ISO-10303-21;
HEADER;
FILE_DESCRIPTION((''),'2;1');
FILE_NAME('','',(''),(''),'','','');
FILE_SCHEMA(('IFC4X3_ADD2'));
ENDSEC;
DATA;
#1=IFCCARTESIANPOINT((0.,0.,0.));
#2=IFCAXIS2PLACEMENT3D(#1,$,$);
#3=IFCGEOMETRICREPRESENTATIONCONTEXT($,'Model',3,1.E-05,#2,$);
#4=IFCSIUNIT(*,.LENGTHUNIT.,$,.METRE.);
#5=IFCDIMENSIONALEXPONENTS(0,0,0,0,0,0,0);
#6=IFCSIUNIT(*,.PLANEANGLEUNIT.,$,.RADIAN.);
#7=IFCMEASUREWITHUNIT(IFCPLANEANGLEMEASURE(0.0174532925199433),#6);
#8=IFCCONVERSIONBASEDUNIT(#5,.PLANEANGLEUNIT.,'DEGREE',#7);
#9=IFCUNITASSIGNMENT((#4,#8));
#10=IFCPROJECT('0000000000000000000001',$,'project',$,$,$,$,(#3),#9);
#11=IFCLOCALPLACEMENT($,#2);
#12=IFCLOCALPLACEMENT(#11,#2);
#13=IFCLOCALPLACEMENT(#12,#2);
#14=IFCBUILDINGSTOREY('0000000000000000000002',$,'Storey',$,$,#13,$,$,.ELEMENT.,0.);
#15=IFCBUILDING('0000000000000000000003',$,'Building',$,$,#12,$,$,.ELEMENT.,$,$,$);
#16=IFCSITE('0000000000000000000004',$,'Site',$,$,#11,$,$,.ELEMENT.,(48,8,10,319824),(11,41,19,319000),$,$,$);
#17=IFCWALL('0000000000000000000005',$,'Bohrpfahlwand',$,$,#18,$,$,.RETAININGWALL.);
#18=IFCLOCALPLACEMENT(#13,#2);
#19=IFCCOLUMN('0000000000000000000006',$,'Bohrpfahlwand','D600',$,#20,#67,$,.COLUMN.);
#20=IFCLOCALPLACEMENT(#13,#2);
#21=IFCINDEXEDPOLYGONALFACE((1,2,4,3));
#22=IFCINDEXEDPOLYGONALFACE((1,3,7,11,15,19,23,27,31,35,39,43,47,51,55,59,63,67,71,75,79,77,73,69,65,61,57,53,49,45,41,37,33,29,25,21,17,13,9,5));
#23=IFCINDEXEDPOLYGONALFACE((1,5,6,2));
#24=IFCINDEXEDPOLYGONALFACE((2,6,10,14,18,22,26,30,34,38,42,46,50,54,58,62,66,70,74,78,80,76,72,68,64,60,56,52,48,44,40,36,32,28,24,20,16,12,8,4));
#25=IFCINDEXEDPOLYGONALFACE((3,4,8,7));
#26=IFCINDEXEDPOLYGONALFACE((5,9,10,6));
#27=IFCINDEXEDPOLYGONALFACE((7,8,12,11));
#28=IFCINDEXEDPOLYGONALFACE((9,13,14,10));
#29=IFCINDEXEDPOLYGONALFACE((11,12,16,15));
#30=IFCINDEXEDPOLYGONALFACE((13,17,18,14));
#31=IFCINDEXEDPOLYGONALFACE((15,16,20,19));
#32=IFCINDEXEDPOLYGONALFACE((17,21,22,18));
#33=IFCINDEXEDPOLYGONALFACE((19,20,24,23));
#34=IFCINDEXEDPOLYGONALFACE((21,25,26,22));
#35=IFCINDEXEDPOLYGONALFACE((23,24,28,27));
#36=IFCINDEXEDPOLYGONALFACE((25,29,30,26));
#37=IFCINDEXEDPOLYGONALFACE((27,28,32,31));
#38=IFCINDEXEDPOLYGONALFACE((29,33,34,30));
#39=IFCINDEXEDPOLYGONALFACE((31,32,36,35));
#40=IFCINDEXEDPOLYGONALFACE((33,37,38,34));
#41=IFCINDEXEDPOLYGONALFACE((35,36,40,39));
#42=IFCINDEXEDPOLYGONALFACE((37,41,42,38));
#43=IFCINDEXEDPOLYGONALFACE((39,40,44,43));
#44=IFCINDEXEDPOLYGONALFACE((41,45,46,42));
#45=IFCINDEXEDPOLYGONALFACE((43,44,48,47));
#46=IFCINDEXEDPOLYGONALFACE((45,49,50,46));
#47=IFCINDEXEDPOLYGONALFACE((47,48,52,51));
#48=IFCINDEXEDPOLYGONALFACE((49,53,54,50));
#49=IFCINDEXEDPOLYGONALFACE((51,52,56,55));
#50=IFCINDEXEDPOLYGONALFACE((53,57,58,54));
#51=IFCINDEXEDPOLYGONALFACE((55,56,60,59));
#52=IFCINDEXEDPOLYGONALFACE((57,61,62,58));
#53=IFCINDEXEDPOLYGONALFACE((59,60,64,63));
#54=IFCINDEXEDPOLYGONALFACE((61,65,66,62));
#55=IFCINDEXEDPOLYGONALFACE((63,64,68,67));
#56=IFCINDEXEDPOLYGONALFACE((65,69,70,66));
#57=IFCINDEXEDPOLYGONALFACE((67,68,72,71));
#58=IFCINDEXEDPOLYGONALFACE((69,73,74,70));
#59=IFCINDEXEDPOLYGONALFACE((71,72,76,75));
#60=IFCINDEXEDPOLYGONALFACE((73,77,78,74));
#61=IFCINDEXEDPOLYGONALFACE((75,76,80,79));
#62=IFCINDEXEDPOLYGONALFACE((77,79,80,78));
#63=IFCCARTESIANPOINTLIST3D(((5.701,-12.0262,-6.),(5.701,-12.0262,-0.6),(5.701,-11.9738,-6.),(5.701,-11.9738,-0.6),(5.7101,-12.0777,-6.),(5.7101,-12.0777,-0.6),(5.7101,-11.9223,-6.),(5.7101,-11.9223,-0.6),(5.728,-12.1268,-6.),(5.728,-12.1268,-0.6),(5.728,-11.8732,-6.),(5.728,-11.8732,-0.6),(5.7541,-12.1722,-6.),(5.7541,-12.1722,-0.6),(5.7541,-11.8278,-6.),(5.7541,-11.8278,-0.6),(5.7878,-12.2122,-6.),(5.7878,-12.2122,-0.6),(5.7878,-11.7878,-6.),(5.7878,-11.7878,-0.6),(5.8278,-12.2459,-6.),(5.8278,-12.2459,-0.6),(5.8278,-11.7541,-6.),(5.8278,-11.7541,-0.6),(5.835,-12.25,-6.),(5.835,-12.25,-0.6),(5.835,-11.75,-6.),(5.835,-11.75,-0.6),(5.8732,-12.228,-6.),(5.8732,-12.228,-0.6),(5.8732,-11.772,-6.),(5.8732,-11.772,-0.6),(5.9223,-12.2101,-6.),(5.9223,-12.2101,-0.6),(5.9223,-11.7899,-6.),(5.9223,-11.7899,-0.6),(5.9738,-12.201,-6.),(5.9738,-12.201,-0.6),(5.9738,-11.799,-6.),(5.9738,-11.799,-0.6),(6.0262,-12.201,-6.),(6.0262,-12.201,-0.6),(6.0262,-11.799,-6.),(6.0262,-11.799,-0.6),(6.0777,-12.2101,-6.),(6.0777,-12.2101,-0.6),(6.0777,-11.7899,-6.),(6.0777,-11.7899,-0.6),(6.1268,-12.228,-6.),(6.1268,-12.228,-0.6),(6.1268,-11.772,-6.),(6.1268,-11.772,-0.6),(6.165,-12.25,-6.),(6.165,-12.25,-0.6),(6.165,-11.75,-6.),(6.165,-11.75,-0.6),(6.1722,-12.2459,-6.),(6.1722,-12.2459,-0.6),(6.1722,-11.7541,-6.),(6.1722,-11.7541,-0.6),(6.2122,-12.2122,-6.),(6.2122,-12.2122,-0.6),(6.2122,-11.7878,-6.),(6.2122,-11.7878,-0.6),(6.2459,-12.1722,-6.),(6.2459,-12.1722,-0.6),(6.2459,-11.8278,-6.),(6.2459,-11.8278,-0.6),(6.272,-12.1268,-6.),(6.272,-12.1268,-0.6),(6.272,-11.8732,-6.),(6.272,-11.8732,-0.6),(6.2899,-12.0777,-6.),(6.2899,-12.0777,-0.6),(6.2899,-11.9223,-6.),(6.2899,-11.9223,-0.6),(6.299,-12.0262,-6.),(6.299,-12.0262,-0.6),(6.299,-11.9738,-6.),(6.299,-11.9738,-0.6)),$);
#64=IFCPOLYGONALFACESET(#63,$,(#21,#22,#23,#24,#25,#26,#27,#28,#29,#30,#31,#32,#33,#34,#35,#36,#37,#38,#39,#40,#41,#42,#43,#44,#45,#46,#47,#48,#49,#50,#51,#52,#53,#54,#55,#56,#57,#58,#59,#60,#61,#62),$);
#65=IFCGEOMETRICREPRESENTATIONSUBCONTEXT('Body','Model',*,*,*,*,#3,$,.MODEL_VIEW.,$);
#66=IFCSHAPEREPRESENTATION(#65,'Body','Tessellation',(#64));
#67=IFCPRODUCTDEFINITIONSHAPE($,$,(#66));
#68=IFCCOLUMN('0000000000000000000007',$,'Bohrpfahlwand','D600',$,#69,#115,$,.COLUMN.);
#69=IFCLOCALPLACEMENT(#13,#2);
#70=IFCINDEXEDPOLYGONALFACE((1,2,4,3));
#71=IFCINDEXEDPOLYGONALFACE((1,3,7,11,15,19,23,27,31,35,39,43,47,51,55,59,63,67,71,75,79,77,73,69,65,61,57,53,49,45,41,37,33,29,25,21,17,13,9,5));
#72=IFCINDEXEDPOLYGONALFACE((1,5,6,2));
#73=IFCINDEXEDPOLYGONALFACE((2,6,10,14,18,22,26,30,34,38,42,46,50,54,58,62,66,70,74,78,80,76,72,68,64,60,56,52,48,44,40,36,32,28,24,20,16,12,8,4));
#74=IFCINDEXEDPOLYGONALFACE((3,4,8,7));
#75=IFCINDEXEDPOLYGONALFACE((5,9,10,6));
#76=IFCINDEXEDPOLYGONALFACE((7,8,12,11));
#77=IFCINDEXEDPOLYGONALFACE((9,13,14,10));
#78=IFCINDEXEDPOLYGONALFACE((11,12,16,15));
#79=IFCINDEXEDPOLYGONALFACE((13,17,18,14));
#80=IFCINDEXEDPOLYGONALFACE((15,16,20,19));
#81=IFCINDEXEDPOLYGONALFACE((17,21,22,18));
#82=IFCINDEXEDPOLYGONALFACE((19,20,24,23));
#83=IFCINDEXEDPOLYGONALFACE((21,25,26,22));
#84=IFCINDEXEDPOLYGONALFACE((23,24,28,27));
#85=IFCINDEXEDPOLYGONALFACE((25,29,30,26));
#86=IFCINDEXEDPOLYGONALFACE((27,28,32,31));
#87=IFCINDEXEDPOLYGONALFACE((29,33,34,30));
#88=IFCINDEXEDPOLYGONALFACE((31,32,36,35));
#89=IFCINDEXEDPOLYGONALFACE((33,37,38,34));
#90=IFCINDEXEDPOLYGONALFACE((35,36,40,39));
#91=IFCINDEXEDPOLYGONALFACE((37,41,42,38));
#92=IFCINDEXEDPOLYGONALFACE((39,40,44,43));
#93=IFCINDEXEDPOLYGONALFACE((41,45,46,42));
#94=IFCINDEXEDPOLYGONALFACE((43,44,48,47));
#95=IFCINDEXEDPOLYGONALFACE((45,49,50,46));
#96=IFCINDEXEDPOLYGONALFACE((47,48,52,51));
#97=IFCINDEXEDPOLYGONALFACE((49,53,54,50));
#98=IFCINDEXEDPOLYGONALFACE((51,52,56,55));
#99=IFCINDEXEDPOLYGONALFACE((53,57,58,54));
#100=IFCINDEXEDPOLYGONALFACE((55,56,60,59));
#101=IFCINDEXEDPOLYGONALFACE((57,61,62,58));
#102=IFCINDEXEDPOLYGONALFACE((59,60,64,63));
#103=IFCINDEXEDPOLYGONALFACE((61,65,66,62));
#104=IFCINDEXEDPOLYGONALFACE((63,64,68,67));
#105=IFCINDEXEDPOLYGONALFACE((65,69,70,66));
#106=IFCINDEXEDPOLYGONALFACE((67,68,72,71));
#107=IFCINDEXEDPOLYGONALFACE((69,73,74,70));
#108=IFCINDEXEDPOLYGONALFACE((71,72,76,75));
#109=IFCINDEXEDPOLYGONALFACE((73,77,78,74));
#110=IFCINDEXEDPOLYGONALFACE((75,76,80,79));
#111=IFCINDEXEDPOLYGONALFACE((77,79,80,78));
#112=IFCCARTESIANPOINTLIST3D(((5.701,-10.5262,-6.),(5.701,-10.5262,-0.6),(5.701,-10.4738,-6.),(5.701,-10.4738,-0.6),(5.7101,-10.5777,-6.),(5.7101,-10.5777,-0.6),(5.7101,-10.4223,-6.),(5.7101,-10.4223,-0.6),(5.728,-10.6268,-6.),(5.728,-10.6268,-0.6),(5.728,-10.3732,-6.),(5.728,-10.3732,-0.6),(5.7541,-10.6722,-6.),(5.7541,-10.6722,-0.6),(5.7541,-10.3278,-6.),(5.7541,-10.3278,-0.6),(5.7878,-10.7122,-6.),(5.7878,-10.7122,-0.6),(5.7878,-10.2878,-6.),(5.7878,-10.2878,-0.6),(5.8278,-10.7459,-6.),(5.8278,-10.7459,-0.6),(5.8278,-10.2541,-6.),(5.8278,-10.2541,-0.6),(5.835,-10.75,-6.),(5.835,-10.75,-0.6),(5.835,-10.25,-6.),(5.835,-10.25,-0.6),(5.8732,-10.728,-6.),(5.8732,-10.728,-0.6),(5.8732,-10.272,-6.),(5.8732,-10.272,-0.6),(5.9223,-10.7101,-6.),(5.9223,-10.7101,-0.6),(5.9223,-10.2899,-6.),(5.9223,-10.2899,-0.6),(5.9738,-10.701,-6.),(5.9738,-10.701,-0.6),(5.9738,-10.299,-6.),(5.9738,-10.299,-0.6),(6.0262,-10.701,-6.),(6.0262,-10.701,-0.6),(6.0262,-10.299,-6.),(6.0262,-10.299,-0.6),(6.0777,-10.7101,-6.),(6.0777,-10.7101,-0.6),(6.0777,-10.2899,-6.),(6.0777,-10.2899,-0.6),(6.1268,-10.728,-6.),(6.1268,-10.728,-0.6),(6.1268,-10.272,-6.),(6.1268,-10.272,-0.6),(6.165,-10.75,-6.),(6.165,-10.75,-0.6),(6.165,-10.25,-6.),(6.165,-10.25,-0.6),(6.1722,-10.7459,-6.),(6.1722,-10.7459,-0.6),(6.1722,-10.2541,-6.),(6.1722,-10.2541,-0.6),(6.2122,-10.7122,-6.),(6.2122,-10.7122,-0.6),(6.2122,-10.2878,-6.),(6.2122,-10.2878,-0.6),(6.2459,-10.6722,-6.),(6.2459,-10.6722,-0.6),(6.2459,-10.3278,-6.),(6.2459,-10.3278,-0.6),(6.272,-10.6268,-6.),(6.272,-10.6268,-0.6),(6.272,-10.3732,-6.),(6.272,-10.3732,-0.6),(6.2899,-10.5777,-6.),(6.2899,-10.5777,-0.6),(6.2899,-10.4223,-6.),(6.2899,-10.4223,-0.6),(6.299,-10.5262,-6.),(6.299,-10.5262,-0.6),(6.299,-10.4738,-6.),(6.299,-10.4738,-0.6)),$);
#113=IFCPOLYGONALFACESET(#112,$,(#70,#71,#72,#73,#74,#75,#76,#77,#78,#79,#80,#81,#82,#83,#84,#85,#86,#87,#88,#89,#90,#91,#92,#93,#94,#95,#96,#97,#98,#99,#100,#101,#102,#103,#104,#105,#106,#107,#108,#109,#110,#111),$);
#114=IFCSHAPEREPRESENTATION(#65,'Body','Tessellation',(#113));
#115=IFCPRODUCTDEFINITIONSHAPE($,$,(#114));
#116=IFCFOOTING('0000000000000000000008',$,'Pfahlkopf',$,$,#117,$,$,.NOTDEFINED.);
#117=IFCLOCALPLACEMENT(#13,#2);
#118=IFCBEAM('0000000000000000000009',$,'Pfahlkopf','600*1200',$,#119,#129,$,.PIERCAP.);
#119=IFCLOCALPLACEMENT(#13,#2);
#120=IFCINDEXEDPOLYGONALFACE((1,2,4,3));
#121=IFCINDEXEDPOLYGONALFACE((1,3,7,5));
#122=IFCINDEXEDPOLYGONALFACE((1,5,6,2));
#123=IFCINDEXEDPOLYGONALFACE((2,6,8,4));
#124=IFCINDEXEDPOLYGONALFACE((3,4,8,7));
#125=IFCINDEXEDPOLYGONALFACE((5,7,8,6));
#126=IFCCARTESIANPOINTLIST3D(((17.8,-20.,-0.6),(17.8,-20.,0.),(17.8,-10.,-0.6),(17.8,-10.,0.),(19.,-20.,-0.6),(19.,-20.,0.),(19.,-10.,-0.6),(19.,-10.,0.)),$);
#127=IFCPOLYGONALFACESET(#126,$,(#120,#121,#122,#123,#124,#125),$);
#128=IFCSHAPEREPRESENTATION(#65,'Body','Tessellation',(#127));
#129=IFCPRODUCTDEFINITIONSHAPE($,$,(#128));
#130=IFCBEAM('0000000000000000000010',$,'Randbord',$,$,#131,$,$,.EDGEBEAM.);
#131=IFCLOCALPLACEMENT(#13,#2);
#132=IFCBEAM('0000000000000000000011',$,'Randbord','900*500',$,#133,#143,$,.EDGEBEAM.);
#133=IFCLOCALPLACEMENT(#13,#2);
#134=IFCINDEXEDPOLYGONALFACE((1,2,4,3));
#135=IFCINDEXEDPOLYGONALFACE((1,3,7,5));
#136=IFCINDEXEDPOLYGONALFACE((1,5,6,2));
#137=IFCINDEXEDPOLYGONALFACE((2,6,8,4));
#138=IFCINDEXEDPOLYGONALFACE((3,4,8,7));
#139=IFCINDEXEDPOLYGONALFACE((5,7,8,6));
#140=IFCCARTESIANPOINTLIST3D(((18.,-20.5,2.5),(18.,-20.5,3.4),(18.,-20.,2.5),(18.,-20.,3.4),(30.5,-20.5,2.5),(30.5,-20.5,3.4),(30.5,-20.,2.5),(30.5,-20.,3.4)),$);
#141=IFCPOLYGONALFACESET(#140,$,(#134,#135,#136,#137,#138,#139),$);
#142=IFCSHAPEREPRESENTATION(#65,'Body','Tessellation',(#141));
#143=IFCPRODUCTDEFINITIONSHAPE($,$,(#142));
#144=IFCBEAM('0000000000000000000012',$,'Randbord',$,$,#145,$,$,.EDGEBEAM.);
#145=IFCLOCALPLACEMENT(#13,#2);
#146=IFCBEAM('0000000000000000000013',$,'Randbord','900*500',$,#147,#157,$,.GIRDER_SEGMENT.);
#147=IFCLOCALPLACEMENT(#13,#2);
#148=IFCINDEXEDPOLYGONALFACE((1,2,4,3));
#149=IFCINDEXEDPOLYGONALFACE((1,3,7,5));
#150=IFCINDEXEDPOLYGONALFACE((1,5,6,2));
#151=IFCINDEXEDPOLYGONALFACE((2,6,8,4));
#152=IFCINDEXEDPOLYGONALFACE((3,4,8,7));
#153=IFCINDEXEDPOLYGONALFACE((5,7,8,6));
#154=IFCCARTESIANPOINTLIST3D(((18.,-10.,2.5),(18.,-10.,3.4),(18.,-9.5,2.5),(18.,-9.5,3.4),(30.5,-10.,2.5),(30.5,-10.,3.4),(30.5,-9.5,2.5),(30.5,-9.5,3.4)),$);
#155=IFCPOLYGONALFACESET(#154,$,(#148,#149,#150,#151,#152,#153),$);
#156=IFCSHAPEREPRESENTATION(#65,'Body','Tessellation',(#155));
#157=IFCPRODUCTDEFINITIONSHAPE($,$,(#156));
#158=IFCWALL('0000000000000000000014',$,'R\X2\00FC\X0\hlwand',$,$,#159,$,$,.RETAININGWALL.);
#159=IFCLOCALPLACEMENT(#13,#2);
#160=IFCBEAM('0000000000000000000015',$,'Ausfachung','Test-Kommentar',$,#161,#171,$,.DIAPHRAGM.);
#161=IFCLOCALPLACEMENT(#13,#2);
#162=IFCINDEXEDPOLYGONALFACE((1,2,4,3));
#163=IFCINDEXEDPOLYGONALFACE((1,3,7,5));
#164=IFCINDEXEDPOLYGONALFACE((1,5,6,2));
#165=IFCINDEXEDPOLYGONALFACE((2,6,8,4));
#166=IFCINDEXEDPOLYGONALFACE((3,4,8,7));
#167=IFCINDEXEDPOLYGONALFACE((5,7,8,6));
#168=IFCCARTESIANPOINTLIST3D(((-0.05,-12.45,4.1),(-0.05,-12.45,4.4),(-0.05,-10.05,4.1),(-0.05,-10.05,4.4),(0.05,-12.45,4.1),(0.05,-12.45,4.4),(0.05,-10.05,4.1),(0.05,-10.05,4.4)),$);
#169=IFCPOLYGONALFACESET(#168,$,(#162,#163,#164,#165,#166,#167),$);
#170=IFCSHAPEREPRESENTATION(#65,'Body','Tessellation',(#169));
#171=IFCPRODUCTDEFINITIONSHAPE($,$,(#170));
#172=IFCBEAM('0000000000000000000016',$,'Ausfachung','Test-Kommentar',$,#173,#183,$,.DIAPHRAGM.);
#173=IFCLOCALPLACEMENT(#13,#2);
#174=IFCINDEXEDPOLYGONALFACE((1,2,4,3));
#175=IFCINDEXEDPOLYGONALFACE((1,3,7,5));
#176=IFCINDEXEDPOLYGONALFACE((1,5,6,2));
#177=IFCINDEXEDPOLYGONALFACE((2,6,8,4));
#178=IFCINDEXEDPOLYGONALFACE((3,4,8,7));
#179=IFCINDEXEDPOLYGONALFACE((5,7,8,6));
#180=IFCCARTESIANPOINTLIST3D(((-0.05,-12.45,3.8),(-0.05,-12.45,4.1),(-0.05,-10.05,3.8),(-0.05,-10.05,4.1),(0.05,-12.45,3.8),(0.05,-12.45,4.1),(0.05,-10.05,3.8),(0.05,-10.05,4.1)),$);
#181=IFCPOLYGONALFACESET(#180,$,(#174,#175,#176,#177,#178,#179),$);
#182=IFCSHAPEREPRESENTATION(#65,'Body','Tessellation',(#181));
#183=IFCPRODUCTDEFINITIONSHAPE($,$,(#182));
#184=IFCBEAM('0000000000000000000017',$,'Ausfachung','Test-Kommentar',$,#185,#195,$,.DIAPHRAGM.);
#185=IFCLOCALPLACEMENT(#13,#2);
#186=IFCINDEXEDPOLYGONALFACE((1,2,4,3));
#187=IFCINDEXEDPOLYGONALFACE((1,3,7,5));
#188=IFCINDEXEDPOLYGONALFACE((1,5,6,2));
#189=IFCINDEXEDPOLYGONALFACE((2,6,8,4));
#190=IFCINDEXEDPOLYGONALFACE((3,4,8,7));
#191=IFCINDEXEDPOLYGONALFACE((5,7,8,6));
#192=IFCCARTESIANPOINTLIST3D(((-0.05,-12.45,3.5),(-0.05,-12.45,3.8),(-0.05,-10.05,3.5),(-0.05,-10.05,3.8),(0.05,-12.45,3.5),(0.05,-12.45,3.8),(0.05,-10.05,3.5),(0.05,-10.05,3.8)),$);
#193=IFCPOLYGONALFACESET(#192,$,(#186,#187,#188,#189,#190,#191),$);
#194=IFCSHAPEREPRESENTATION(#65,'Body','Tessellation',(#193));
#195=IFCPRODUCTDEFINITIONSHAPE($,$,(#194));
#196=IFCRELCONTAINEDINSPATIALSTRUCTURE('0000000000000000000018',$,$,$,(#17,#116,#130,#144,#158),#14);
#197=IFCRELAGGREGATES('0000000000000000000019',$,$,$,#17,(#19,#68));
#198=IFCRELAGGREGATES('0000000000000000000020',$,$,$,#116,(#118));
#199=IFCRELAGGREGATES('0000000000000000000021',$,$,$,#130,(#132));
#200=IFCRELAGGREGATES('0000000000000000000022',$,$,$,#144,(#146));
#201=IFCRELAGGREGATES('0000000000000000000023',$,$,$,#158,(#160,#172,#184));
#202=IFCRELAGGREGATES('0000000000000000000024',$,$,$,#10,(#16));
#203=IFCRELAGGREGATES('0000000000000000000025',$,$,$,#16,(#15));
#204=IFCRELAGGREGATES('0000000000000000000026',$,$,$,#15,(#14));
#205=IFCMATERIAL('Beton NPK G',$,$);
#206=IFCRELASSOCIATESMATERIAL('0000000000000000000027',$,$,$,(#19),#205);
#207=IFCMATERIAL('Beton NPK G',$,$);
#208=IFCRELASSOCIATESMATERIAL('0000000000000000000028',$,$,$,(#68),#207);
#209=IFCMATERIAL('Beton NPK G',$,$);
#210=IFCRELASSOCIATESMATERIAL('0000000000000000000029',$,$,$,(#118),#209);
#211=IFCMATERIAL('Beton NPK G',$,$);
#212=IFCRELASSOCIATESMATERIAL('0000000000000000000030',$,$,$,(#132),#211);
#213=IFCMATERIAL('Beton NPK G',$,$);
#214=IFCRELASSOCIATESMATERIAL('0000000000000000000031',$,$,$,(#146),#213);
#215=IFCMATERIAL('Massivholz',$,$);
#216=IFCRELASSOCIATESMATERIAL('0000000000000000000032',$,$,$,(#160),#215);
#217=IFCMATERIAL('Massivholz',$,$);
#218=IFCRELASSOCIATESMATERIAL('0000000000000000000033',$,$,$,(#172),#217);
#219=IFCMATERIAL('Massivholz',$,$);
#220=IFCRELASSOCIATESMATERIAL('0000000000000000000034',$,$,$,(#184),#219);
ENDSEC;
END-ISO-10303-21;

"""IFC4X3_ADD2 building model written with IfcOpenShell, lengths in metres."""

from ifc_helpers import new_model, entity, si_unit, converted_unit, frame, frame_2d, origin, origin_with_axes, place, context, subcontext, project, spatial, polyline, rectangle, outline, extrude, material, element, aggregate, save


model = new_model("IFC4X3_ADD2")

# Units and contexts
model_context = context("Model", 3, precision=1e-05, world=origin())
body_context = subcontext(model_context, "Body", "Model", "MODEL_VIEW")
ifc_project = project(units=[si_unit("LENGTHUNIT", "METRE"), converted_unit("PLANEANGLEUNIT", "DEGREE", entity("IfcPlaneAngleMeasure", 0.0174532925199433), si_unit("PLANEANGLEUNIT", "RADIAN"), dimensions=[0, 0, 0, 0, 0, 0, 0])], contexts=[model_context])

# Site, building, storey
site_placement = place(None, origin())
site = spatial("IfcSite", under=ifc_project, at=site_placement, Name="Site", CompositionType="ELEMENT", RefLatitude=(48, 8, 10, 319824), RefLongitude=(11, 41, 19, 319000))
building_placement = place(site_placement, origin())
building = spatial("IfcBuilding", under=site, at=building_placement, Name="Building", CompositionType="ELEMENT")
storey_placement = place(building_placement, origin())
storey = spatial("IfcBuildingStorey", under=building, at=storey_placement, Name="Storey", CompositionType="ELEMENT", Elevation=0.0)

# Wall, columns
wall_1_placement = place(storey_placement, origin())
wall_1 = element("IfcWall", 1, at=wall_1_placement, inside=storey, Name="Bohrpfahlwand", PredefinedType="RETAININGWALL")
ifc_material_1 = material(Name="Beton NPK G")
column_1_placement = place(wall_1_placement, frame((5.701, -12.25, -6.0)))
column_1 = element("IfcColumn", 2, at=column_1_placement, material=ifc_material_1, Name="Bohrpfahlwand", Description="D600", PredefinedType="COLUMN", context=body_context, shape_type="SweptSolid", body=[
    extrude(outline(polyline([(0.464, 0.5), (0.4258, 0.478), (0.3767, 0.4601), (0.3252, 0.451), (0.2728, 0.451), (0.2213, 0.4601), (0.1722, 0.478), (0.134, 0.5), (0.1268, 0.4959), (0.0868, 0.4622), (0.0531, 0.4222), (0.027, 0.3768), (0.0091, 0.3277), (0.0, 0.2762), (0.0, 0.2238), (0.0091, 0.1723), (0.027, 0.1232), (0.0531, 0.0778), (0.0868, 0.0378), (0.1268, 0.0041), (0.134, 0.0), (0.1722, 0.022), (0.2213, 0.0399), (0.2728, 0.049), (0.3252, 0.049), (0.3767, 0.0399), (0.4258, 0.022), (0.464, 0.0), (0.4712, 0.0041), (0.5112, 0.0378), (0.5449, 0.0778), (0.571, 0.1232), (0.5889, 0.1723), (0.598, 0.2238), (0.598, 0.2762), (0.5889, 0.3277), (0.571, 0.3768), (0.5449, 0.4222), (0.5112, 0.4622), (0.4712, 0.4959), (0.464, 0.5)])), origin_with_axes(), (0.0, 0.0, 1.0), 5.4),
])
ifc_material_2 = material(Name="Beton NPK G")
column_2_placement = place(wall_1_placement, frame((5.701, -10.75, -6.0)))
column_2 = element("IfcColumn", 3, at=column_2_placement, material=ifc_material_2, Name="Bohrpfahlwand", Description="D600", PredefinedType="COLUMN", context=body_context, shape_type="SweptSolid", body=[
    extrude(outline(polyline([(0.464, 0.5), (0.4258, 0.478), (0.3767, 0.4601), (0.3252, 0.451), (0.2728, 0.451), (0.2213, 0.4601), (0.1722, 0.478), (0.134, 0.5), (0.1268, 0.4959), (0.0868, 0.4622), (0.0531, 0.4222), (0.027, 0.3768), (0.0091, 0.3277), (0.0, 0.2762), (0.0, 0.2238), (0.0091, 0.1723), (0.027, 0.1232), (0.0531, 0.0778), (0.0868, 0.0378), (0.1268, 0.0041), (0.134, 0.0), (0.1722, 0.022), (0.2213, 0.0399), (0.2728, 0.049), (0.3252, 0.049), (0.3767, 0.0399), (0.4258, 0.022), (0.464, 0.0), (0.4712, 0.0041), (0.5112, 0.0378), (0.5449, 0.0778), (0.571, 0.1232), (0.5889, 0.1723), (0.598, 0.2238), (0.598, 0.2762), (0.5889, 0.3277), (0.571, 0.3768), (0.5449, 0.4222), (0.5112, 0.4622), (0.4712, 0.4959), (0.464, 0.5)])), origin_with_axes(), (0.0, 0.0, 1.0), 5.4),
])
aggregate(wall_1, [column_1, column_2])

# Footing, beam
footing_placement = place(storey_placement, origin())
footing = element("IfcFooting", 4, at=footing_placement, inside=storey, Name="Pfahlkopf", PredefinedType="NOTDEFINED")
ifc_material_3 = material(Name="Beton NPK G")
beam_1_placement = place(footing_placement, frame((17.8, -10.0, -0.6), z_axis=(0.0, 0.0, 1.0), x_axis=(0.0, -1.0, 0.0)))
beam_1 = element("IfcBeam", 5, at=beam_1_placement, material=ifc_material_3, Name="Pfahlkopf", Description="600*1200", PredefinedType="PIERCAP", context=body_context, shape_type="SweptSolid", body=[
    extrude(rectangle(XDim=1.2, YDim=0.6, at=frame_2d((0.6, 0.3), x_axis=(1.0, 0.0))), frame((0.0, 0.0, 0.0), z_axis=(1.0, 0.0, 0.0), x_axis=(0.0, 1.0, 0.0)), (0.0, 0.0, 1.0), 10.0),
])
aggregate(footing, [beam_1])

# Beams
beam_2_placement = place(storey_placement, origin())
beam_2 = element("IfcBeam", 6, at=beam_2_placement, inside=storey, Name="Randbord", PredefinedType="EDGEBEAM")
ifc_material_4 = material(Name="Beton NPK G")
beam_3_placement = place(beam_2_placement, frame((30.5, -20.5, 2.5), z_axis=(0.0, 0.0, 1.0), x_axis=(0.0, 1.0, 0.0)))
beam_3 = element("IfcBeam", 7, at=beam_3_placement, material=ifc_material_4, Name="Randbord", Description="900*500", PredefinedType="EDGEBEAM", context=body_context, shape_type="SweptSolid", body=[
    extrude(rectangle(XDim=12.5, YDim=0.9, at=frame_2d((6.25, 0.45), x_axis=(1.0, 0.0))), frame((0.0, 0.0, 0.0), z_axis=(1.0, 0.0, 0.0), x_axis=(0.0, 1.0, 0.0)), (0.0, 0.0, 1.0), 0.5),
])
aggregate(beam_2, [beam_3])
beam_4_placement = place(storey_placement, origin())
beam_4 = element("IfcBeam", 8, at=beam_4_placement, inside=storey, Name="Randbord", PredefinedType="EDGEBEAM")
ifc_material_5 = material(Name="Beton NPK G")
beam_5_placement = place(beam_4_placement, frame((30.5, -10.0, 2.5), z_axis=(0.0, 0.0, 1.0), x_axis=(0.0, 1.0, 0.0)))
beam_5 = element("IfcBeam", 9, at=beam_5_placement, material=ifc_material_5, Name="Randbord", Description="900*500", PredefinedType="GIRDER_SEGMENT", context=body_context, shape_type="SweptSolid", body=[
    extrude(rectangle(XDim=12.5, YDim=0.9, at=frame_2d((6.25, 0.45), x_axis=(1.0, 0.0))), frame((0.0, 0.0, 0.0), z_axis=(1.0, 0.0, 0.0), x_axis=(0.0, 1.0, 0.0)), (0.0, 0.0, 1.0), 0.5),
])
aggregate(beam_4, [beam_5])

# Wall, beams
wall_2_placement = place(storey_placement, origin())
wall_2 = element("IfcWall", 10, at=wall_2_placement, inside=storey, Name="Rühlwand", PredefinedType="RETAININGWALL")
ifc_material_6 = material(Name="Massivholz")
beam_6_placement = place(wall_2_placement, frame((0.05, -10.05, 4.1), z_axis=(0.0, 0.0, 1.0), x_axis=(-1.0, 0.0, 0.0)))
beam_6 = element("IfcBeam", 11, at=beam_6_placement, material=ifc_material_6, Name="Ausfachung", Description="Test-Kommentar", PredefinedType="DIAPHRAGM", context=body_context, shape_type="SweptSolid", body=[
    extrude(rectangle(XDim=2.4, YDim=0.3, at=frame_2d((1.2, 0.15), x_axis=(1.0, 0.0))), frame((0.0, 0.0, 0.0), z_axis=(1.0, 0.0, 0.0), x_axis=(0.0, 1.0, 0.0)), (0.0, 0.0, 1.0), 0.1),
])
ifc_material_7 = material(Name="Massivholz")
beam_7_placement = place(wall_2_placement, frame((0.05, -10.05, 3.8), z_axis=(0.0, 0.0, 1.0), x_axis=(-1.0, 0.0, 0.0)))
beam_7 = element("IfcBeam", 12, at=beam_7_placement, material=ifc_material_7, Name="Ausfachung", Description="Test-Kommentar", PredefinedType="DIAPHRAGM", context=body_context, shape_type="SweptSolid", body=[
    extrude(rectangle(XDim=2.4, YDim=0.3, at=frame_2d((1.2, 0.15), x_axis=(1.0, 0.0))), frame((0.0, 0.0, 0.0), z_axis=(1.0, 0.0, 0.0), x_axis=(0.0, 1.0, 0.0)), (0.0, 0.0, 1.0), 0.1),
])
ifc_material_8 = material(Name="Massivholz")
beam_8_placement = place(wall_2_placement, frame((0.05, -10.05, 3.5), z_axis=(0.0, 0.0, 1.0), x_axis=(-1.0, 0.0, 0.0)))
beam_8 = element("IfcBeam", 13, at=beam_8_placement, material=ifc_material_8, Name="Ausfachung", Description="Test-Kommentar", PredefinedType="DIAPHRAGM", context=body_context, shape_type="SweptSolid", body=[
    extrude(rectangle(XDim=2.4, YDim=0.3, at=frame_2d((1.2, 0.15), x_axis=(1.0, 0.0))), frame((0.0, 0.0, 0.0), z_axis=(1.0, 0.0, 0.0), x_axis=(0.0, 1.0, 0.0)), (0.0, 0.0, 1.0), 0.1),
])
aggregate(wall_2, [beam_6, beam_7, beam_8])

save(model, "model.ifc")
